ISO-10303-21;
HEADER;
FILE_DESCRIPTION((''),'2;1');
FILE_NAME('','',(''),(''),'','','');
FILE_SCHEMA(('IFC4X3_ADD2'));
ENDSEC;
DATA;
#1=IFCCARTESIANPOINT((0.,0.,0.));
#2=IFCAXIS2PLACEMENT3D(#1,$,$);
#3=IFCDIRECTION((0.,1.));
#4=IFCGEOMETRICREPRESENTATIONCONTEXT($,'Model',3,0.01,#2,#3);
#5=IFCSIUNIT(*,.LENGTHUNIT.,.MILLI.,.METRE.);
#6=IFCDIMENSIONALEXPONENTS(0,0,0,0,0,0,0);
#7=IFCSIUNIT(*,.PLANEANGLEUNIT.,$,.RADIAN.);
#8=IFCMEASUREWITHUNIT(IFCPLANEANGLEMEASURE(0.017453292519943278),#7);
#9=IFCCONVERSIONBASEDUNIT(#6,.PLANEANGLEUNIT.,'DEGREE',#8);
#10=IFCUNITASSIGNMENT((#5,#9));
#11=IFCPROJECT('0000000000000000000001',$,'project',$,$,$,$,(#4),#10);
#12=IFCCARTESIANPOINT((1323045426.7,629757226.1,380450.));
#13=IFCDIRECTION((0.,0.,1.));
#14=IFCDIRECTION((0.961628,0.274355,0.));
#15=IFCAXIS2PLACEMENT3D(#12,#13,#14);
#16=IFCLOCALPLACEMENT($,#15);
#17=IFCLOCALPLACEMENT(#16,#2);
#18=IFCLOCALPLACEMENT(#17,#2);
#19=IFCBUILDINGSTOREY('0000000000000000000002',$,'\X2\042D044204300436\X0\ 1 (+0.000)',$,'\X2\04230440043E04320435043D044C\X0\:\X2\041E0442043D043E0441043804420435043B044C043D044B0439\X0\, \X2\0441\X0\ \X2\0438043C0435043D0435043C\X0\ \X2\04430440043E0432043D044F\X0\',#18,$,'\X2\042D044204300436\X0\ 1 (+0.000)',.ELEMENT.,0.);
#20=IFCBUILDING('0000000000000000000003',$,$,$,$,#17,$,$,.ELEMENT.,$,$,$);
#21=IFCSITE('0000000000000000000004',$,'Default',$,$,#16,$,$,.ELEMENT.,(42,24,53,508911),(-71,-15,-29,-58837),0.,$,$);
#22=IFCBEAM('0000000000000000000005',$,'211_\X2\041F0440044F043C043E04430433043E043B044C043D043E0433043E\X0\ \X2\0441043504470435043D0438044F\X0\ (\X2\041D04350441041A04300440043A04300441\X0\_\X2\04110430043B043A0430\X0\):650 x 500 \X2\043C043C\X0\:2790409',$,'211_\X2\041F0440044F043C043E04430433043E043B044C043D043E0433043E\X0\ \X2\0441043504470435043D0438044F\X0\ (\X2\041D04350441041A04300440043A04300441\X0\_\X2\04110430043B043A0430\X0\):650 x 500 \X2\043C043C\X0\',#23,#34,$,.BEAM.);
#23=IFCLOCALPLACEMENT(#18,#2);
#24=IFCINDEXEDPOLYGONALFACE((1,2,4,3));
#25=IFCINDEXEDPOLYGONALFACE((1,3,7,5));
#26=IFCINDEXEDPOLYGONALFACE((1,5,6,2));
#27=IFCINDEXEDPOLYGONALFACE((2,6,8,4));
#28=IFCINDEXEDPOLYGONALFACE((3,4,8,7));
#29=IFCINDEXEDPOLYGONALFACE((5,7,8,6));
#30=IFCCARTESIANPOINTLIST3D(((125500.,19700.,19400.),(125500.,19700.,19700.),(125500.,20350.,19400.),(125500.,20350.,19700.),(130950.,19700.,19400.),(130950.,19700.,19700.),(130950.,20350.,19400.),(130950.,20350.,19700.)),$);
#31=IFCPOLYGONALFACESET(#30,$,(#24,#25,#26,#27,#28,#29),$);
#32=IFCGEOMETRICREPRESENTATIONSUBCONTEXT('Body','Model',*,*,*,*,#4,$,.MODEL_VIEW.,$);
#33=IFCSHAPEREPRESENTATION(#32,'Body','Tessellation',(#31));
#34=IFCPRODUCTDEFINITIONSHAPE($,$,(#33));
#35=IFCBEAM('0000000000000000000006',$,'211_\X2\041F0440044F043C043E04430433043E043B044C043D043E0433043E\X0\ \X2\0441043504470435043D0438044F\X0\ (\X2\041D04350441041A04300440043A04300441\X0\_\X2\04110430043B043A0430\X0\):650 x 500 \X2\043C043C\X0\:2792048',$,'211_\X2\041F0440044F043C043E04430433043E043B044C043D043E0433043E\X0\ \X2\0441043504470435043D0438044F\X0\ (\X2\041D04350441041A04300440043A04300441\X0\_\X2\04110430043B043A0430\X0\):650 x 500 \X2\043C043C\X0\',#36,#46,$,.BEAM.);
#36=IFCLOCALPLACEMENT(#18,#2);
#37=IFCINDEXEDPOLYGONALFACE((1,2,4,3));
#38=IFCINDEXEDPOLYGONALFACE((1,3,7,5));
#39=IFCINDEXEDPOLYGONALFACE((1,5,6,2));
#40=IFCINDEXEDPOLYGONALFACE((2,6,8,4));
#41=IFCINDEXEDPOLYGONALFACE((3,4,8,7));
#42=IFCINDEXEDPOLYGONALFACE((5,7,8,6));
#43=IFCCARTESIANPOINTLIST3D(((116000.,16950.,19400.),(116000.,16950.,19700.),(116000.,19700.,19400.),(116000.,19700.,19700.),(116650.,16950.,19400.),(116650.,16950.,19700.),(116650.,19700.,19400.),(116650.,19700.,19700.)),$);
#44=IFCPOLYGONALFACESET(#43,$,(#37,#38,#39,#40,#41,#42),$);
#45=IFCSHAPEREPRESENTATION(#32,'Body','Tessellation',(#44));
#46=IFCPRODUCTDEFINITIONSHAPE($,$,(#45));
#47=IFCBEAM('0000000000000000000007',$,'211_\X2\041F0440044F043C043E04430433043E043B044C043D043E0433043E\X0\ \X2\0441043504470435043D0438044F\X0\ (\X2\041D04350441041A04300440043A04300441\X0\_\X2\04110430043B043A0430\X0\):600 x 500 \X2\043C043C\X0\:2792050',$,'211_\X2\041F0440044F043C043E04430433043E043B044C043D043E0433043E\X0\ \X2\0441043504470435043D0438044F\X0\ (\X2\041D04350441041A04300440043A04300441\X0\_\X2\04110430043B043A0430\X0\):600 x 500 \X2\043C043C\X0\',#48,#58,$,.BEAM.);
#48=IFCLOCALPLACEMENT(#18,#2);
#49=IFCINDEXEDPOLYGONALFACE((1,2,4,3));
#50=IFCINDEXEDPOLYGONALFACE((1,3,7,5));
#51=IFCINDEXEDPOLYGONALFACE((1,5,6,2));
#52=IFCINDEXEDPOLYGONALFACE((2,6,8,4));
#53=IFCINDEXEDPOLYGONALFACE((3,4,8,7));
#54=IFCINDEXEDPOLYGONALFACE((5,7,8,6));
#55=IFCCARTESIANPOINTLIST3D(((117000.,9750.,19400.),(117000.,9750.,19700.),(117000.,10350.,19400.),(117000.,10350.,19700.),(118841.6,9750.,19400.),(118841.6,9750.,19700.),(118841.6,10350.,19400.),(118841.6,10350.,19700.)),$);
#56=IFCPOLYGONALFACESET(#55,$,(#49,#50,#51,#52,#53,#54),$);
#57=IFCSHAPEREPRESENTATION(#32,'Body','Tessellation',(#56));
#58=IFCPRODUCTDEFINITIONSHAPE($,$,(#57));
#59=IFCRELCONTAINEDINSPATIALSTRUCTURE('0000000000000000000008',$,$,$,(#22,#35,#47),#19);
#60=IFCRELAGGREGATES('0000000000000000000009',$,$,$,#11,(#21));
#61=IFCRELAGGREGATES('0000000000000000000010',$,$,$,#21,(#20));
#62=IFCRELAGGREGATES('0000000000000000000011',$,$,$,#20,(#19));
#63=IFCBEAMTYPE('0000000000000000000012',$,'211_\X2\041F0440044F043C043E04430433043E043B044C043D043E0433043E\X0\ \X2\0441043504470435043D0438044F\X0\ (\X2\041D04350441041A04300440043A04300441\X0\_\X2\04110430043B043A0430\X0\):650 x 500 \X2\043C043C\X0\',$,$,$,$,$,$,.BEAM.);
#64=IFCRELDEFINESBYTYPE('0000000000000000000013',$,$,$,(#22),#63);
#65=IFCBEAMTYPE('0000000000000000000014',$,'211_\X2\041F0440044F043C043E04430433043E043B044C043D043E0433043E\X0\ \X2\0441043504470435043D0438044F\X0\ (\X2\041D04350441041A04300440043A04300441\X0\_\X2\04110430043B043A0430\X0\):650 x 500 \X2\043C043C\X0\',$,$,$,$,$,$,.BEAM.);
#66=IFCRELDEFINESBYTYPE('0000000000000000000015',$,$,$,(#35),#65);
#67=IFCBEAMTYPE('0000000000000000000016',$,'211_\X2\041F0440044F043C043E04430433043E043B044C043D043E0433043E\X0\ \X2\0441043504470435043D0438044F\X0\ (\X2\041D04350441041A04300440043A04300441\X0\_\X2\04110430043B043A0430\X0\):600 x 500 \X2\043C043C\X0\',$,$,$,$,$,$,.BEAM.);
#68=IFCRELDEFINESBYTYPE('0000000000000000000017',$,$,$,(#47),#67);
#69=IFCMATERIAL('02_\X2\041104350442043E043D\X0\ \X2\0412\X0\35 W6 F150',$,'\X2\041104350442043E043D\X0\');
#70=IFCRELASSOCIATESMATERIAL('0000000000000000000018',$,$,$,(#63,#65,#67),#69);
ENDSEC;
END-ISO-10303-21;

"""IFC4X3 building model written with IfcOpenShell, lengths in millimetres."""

from ifc_helpers import new_model, entity, si_unit, converted_unit, direction, frame, frame_2d, origin, place, context, subcontext, project, spatial, rectangle, extrude, source, transform, mapped, material, material_profile, profile_set, type_object, type_shapes, element, save


model = new_model("IFC4X3")

# Units and contexts
model_context = context("Model", 3, precision=0.01, world=origin(), true_north=direction((0.0, 1.0)))
body_context = subcontext(model_context, "Body", "Model", "MODEL_VIEW")
ifc_project = project(units=[si_unit("LENGTHUNIT", "METRE", prefix="MILLI"), converted_unit("PLANEANGLEUNIT", "DEGREE", entity("IfcPlaneAngleMeasure", 0.017453292519943278), si_unit("PLANEANGLEUNIT", "RADIAN"), dimensions=[0, 0, 0, 0, 0, 0, 0])], contexts=[model_context])

# Site, building, storey
site_placement = place(None, frame((1323045426.7, 629757226.1, 380450.0), z_axis=(0.0, 0.0, 1.0), x_axis=(0.961628, 0.274355, 0.0)))
site = spatial("IfcSite", under=ifc_project, at=site_placement, Name="Default", CompositionType="ELEMENT", RefLatitude=(42, 24, 53, 508911), RefLongitude=(-71, -15, -29, -58837), RefElevation=0.0)
building_placement = place(site_placement, origin())
building = spatial("IfcBuilding", under=site, at=building_placement, CompositionType="ELEMENT")
storey_placement = place(building_placement, origin())
storey = spatial("IfcBuildingStorey", under=building, at=storey_placement, Name="Этаж 1 (+0.000)", ObjectType="Уровень:Относительный, с именем уровня", LongName="Этаж 1 (+0.000)", CompositionType="ELEMENT", Elevation=0.0)

# Beams
ifc_material = material(Name="02_Бетон В35 W6 F150", Category="Бетон")
ifc_material_profile_1 = material_profile(ifc_material, rectangle(XDim=300.0, YDim=650.0, at=frame_2d((0.0, 0.0), x_axis=(1.0, 0.0))), Name="650 x 500 мм")
ifc_profile_set_1 = profile_set([ifc_material_profile_1], Name="650 x 500 мм")
beam_type_1 = type_object("IfcBeamType", Name="211_Прямоугольного сечения (НесКаркас_Балка):650 x 500 мм", PredefinedType="BEAM", material=ifc_profile_set_1)
shared_shape_1 = source(origin(), body_context, "Body", "SweptSolid", [
    extrude(rectangle(XDim=300.0, YDim=650.0, at=frame_2d((0.0, 0.0), x_axis=(1.0, 0.0))), frame((125500.0, 20025.0, 19550.0), z_axis=(1.0, 0.0, 0.0), x_axis=(0.0, 0.0, -1.0)), (0.0, 0.0, 1.0), 5450.0),
])
type_shapes(beam_type_1, [shared_shape_1])
beam_1_placement = place(storey_placement, origin())
element("IfcBeam", 1, at=beam_1_placement, inside=storey, type_object=beam_type_1, Name="211_Прямоугольного сечения (НесКаркас_Балка):650 x 500 мм:2790409", ObjectType="211_Прямоугольного сечения (НесКаркас_Балка):650 x 500 мм", PredefinedType="BEAM", context=body_context, shape_type="MappedRepresentation", body=[
    mapped(shared_shape_1, transform((0.0, 0.0, 0.0), scale=1.0)),
])
beam_type_2 = type_object("IfcBeamType", Name="211_Прямоугольного сечения (НесКаркас_Балка):650 x 500 мм", PredefinedType="BEAM", material=ifc_profile_set_1)
shared_shape_2 = source(origin(), body_context, "Body", "SweptSolid", [
    extrude(rectangle(XDim=300.0, YDim=650.0, at=frame_2d((0.0, 0.0), x_axis=(0.0, 1.0))), frame((116325.0, 19700.0, 19550.0), z_axis=(0.0, -1.0, 0.0), x_axis=(-1.0, 0.0, 0.0)), (0.0, 0.0, 1.0), 2750.0),
])
type_shapes(beam_type_2, [shared_shape_2])
beam_2_placement = place(storey_placement, origin())
element("IfcBeam", 2, at=beam_2_placement, inside=storey, type_object=beam_type_2, Name="211_Прямоугольного сечения (НесКаркас_Балка):650 x 500 мм:2792048", ObjectType="211_Прямоугольного сечения (НесКаркас_Балка):650 x 500 мм", PredefinedType="BEAM", context=body_context, shape_type="MappedRepresentation", body=[
    mapped(shared_shape_2, transform((0.0, 0.0, 0.0), scale=1.0)),
])
ifc_material_profile_2 = material_profile(ifc_material, rectangle(XDim=300.0, YDim=600.0, at=frame_2d((0.0, 0.0), x_axis=(1.0, 0.0))), Name="600 x 500 мм")
ifc_profile_set_2 = profile_set([ifc_material_profile_2], Name="600 x 500 мм")
beam_type_3 = type_object("IfcBeamType", Name="211_Прямоугольного сечения (НесКаркас_Балка):600 x 500 мм", PredefinedType="BEAM", material=ifc_profile_set_2)
shared_shape_3 = source(origin(), body_context, "Body", "SweptSolid", [
    extrude(rectangle(XDim=300.0, YDim=600.0, at=frame_2d((0.0, 0.0), x_axis=(1.0, 0.0))), frame((117000.0, 10050.0, 19550.0), z_axis=(1.0, 0.0, 0.0), x_axis=(0.0, 0.0, -1.0)), (0.0, 0.0, 1.0), 1841.6),
])
type_shapes(beam_type_3, [shared_shape_3])
beam_3_placement = place(storey_placement, origin())
element("IfcBeam", 3, at=beam_3_placement, inside=storey, type_object=beam_type_3, Name="211_Прямоугольного сечения (НесКаркас_Балка):600 x 500 мм:2792050", ObjectType="211_Прямоугольного сечения (НесКаркас_Балка):600 x 500 мм", PredefinedType="BEAM", context=body_context, shape_type="MappedRepresentation", body=[
    mapped(shared_shape_3, transform((0.0, 0.0, 0.0), scale=1.0)),
])

save(model, "model.ifc")
